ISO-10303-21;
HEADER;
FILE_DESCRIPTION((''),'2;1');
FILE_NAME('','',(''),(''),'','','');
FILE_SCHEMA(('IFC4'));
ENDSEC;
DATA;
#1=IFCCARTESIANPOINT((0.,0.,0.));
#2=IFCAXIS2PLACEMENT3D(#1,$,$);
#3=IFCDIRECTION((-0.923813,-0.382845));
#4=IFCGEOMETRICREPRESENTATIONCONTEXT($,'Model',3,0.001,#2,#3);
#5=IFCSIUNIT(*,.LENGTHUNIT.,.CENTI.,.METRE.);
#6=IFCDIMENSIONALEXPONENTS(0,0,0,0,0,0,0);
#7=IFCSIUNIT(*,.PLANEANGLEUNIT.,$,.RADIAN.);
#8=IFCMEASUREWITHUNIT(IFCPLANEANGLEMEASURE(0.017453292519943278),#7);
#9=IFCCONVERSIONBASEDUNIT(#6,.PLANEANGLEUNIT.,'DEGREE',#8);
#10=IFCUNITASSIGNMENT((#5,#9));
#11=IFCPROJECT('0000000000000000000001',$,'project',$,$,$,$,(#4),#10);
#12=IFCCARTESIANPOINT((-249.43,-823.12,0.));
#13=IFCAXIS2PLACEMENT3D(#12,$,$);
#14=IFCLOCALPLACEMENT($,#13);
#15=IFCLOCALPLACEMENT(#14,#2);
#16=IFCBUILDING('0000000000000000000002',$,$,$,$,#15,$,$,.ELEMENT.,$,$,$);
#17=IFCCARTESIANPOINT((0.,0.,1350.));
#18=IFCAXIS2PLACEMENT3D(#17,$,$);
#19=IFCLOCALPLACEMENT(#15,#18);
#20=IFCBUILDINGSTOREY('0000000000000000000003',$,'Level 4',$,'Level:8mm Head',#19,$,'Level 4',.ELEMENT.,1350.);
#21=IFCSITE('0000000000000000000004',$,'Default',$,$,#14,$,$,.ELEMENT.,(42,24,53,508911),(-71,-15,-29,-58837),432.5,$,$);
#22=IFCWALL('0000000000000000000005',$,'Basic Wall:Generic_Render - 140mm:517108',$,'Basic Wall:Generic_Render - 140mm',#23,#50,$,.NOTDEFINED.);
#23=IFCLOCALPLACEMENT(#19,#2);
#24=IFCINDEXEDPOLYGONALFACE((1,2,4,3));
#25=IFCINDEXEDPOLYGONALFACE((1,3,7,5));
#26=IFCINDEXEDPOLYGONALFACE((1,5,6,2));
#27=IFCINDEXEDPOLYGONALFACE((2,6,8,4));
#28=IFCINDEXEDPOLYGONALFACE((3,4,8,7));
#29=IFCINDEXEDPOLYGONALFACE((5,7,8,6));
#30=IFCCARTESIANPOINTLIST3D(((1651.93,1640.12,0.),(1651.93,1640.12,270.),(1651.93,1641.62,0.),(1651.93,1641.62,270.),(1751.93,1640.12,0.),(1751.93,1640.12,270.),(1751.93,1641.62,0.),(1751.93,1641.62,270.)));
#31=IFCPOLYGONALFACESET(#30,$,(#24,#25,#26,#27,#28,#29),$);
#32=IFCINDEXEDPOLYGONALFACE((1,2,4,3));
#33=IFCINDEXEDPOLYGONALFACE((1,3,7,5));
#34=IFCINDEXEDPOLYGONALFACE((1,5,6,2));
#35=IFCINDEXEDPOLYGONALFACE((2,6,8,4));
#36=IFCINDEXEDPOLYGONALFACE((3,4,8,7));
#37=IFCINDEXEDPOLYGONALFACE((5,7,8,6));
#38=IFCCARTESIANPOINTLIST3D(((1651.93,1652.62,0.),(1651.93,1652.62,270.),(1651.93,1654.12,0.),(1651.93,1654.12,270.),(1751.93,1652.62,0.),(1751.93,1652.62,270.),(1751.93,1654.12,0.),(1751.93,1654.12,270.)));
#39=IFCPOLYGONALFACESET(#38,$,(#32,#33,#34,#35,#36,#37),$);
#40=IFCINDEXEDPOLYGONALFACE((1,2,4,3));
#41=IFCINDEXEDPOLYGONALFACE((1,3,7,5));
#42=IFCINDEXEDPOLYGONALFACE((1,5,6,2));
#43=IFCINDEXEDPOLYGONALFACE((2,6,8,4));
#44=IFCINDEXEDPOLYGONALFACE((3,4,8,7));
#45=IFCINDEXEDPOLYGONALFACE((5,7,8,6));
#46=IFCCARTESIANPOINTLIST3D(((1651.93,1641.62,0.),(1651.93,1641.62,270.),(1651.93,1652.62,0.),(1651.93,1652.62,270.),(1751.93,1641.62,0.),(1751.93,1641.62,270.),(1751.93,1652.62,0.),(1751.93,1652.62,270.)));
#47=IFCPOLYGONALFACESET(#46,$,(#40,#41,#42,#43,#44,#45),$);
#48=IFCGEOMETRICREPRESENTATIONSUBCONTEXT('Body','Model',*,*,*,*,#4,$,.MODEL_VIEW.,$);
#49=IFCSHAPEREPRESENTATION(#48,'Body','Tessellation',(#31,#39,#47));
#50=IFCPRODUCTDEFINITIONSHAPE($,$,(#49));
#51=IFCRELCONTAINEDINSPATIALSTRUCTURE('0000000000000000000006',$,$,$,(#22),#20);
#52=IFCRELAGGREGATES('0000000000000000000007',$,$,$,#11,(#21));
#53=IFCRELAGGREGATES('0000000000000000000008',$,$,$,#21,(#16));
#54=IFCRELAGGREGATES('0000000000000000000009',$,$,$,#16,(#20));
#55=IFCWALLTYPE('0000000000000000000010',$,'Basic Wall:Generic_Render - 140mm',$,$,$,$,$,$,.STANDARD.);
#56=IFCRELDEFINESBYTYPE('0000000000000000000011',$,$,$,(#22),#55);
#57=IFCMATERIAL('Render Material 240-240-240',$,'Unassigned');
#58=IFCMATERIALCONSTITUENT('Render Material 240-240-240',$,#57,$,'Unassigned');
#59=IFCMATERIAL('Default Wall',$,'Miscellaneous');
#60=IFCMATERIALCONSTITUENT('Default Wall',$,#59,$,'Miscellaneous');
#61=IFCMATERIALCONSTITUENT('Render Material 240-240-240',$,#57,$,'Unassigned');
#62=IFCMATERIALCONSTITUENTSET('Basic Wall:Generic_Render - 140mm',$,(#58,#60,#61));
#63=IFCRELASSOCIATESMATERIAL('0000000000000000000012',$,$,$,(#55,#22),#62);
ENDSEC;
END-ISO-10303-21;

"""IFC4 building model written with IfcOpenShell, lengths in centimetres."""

from ifc_helpers import new_model, entity, si_unit, converted_unit, direction, frame, origin, place, context, subcontext, project, spatial, indexed_curve, outline, extrude, material, constituent, constituent_set, type_object, element, save


model = new_model("IFC4")

# Units and contexts
model_context = context("Model", 3, precision=0.001, world=origin(), true_north=direction((-0.923813, -0.382845)))
body_context = subcontext(model_context, "Body", "Model", "MODEL_VIEW")
ifc_project = project(units=[si_unit("LENGTHUNIT", "METRE", prefix="CENTI"), converted_unit("PLANEANGLEUNIT", "DEGREE", entity("IfcPlaneAngleMeasure", 0.017453292519943278), si_unit("PLANEANGLEUNIT", "RADIAN"), dimensions=[0, 0, 0, 0, 0, 0, 0])], contexts=[model_context])

# Site, building, storey
site_placement = place(None, frame((-249.43, -823.12, 0.0)))
site = spatial("IfcSite", under=ifc_project, at=site_placement, Name="Default", CompositionType="ELEMENT", RefLatitude=(42, 24, 53, 508911), RefLongitude=(-71, -15, -29, -58837), RefElevation=432.5)
building_placement = place(site_placement, origin())
building = spatial("IfcBuilding", under=site, at=building_placement, CompositionType="ELEMENT")
storey_placement = place(building_placement, frame((0.0, 0.0, 1350.0)))
storey = spatial("IfcBuildingStorey", under=building, at=storey_placement, Name="Level 4", ObjectType="Level:8mm Head", LongName="Level 4", CompositionType="ELEMENT", Elevation=1350.0)

# Shared definitions
ifc_material_1 = material(Name="Render Material 240-240-240", Category="Unassigned")
ifc_material_2 = material(Name="Default Wall", Category="Miscellaneous")

# Wall
ifc_constituent_1 = constituent(ifc_material_1, Name="Render Material 240-240-240", Category="Unassigned")
ifc_constituent_2 = constituent(ifc_material_2, Name="Default Wall", Category="Miscellaneous")
ifc_constituent_3 = constituent(ifc_material_1, Name="Render Material 240-240-240", Category="Unassigned")
ifc_constituent_set_1 = constituent_set(constituents=[ifc_constituent_1, ifc_constituent_2, ifc_constituent_3], Name="Basic Wall:Generic_Render - 140mm")
wall_type_1 = type_object("IfcWallType", Name="Basic Wall:Generic_Render - 140mm", PredefinedType="STANDARD", material=ifc_constituent_set_1)
wall_1_placement = place(storey_placement, frame((1651.93, 1647.12, 0.0)))
element("IfcWall", 1, at=wall_1_placement, inside=storey, type_object=wall_type_1, material=ifc_constituent_set_1, Name="Basic Wall:Generic_Render - 140mm:517108", ObjectType="Basic Wall:Generic_Render - 140mm", PredefinedType="NOTDEFINED", context=body_context, shape_type="SweptSolid", body=[
    extrude(outline(indexed_curve([(-0.75, -50.0), (0.75, -50.0), (0.75, 50.0), (-0.75, 50.0), (-0.75, -50.0)], self_intersect=False)), frame((50.0, -6.25, 0.0), z_axis=(0.0, 0.0, 1.0), x_axis=(0.0, 1.0, 0.0)), (0.0, 0.0, 1.0), 270.0),
    extrude(outline(indexed_curve([(-0.75, -50.0), (0.75, -50.0), (0.75, 50.0), (-0.75, 50.0), (-0.75, -50.0)], self_intersect=False)), frame((50.0, 6.25, 0.0), z_axis=(0.0, 0.0, 1.0), x_axis=(0.0, -1.0, 0.0)), (0.0, 0.0, 1.0), 270.0),
    extrude(outline(indexed_curve([(-50.0, -5.5), (50.0, -5.5), (50.0, 5.5), (-50.0, 5.5), (-50.0, -5.5)], self_intersect=False)), frame((50.0, 0.0, 0.0)), (0.0, 0.0, 1.0), 270.0),
])

save(model, "model.ifc")
